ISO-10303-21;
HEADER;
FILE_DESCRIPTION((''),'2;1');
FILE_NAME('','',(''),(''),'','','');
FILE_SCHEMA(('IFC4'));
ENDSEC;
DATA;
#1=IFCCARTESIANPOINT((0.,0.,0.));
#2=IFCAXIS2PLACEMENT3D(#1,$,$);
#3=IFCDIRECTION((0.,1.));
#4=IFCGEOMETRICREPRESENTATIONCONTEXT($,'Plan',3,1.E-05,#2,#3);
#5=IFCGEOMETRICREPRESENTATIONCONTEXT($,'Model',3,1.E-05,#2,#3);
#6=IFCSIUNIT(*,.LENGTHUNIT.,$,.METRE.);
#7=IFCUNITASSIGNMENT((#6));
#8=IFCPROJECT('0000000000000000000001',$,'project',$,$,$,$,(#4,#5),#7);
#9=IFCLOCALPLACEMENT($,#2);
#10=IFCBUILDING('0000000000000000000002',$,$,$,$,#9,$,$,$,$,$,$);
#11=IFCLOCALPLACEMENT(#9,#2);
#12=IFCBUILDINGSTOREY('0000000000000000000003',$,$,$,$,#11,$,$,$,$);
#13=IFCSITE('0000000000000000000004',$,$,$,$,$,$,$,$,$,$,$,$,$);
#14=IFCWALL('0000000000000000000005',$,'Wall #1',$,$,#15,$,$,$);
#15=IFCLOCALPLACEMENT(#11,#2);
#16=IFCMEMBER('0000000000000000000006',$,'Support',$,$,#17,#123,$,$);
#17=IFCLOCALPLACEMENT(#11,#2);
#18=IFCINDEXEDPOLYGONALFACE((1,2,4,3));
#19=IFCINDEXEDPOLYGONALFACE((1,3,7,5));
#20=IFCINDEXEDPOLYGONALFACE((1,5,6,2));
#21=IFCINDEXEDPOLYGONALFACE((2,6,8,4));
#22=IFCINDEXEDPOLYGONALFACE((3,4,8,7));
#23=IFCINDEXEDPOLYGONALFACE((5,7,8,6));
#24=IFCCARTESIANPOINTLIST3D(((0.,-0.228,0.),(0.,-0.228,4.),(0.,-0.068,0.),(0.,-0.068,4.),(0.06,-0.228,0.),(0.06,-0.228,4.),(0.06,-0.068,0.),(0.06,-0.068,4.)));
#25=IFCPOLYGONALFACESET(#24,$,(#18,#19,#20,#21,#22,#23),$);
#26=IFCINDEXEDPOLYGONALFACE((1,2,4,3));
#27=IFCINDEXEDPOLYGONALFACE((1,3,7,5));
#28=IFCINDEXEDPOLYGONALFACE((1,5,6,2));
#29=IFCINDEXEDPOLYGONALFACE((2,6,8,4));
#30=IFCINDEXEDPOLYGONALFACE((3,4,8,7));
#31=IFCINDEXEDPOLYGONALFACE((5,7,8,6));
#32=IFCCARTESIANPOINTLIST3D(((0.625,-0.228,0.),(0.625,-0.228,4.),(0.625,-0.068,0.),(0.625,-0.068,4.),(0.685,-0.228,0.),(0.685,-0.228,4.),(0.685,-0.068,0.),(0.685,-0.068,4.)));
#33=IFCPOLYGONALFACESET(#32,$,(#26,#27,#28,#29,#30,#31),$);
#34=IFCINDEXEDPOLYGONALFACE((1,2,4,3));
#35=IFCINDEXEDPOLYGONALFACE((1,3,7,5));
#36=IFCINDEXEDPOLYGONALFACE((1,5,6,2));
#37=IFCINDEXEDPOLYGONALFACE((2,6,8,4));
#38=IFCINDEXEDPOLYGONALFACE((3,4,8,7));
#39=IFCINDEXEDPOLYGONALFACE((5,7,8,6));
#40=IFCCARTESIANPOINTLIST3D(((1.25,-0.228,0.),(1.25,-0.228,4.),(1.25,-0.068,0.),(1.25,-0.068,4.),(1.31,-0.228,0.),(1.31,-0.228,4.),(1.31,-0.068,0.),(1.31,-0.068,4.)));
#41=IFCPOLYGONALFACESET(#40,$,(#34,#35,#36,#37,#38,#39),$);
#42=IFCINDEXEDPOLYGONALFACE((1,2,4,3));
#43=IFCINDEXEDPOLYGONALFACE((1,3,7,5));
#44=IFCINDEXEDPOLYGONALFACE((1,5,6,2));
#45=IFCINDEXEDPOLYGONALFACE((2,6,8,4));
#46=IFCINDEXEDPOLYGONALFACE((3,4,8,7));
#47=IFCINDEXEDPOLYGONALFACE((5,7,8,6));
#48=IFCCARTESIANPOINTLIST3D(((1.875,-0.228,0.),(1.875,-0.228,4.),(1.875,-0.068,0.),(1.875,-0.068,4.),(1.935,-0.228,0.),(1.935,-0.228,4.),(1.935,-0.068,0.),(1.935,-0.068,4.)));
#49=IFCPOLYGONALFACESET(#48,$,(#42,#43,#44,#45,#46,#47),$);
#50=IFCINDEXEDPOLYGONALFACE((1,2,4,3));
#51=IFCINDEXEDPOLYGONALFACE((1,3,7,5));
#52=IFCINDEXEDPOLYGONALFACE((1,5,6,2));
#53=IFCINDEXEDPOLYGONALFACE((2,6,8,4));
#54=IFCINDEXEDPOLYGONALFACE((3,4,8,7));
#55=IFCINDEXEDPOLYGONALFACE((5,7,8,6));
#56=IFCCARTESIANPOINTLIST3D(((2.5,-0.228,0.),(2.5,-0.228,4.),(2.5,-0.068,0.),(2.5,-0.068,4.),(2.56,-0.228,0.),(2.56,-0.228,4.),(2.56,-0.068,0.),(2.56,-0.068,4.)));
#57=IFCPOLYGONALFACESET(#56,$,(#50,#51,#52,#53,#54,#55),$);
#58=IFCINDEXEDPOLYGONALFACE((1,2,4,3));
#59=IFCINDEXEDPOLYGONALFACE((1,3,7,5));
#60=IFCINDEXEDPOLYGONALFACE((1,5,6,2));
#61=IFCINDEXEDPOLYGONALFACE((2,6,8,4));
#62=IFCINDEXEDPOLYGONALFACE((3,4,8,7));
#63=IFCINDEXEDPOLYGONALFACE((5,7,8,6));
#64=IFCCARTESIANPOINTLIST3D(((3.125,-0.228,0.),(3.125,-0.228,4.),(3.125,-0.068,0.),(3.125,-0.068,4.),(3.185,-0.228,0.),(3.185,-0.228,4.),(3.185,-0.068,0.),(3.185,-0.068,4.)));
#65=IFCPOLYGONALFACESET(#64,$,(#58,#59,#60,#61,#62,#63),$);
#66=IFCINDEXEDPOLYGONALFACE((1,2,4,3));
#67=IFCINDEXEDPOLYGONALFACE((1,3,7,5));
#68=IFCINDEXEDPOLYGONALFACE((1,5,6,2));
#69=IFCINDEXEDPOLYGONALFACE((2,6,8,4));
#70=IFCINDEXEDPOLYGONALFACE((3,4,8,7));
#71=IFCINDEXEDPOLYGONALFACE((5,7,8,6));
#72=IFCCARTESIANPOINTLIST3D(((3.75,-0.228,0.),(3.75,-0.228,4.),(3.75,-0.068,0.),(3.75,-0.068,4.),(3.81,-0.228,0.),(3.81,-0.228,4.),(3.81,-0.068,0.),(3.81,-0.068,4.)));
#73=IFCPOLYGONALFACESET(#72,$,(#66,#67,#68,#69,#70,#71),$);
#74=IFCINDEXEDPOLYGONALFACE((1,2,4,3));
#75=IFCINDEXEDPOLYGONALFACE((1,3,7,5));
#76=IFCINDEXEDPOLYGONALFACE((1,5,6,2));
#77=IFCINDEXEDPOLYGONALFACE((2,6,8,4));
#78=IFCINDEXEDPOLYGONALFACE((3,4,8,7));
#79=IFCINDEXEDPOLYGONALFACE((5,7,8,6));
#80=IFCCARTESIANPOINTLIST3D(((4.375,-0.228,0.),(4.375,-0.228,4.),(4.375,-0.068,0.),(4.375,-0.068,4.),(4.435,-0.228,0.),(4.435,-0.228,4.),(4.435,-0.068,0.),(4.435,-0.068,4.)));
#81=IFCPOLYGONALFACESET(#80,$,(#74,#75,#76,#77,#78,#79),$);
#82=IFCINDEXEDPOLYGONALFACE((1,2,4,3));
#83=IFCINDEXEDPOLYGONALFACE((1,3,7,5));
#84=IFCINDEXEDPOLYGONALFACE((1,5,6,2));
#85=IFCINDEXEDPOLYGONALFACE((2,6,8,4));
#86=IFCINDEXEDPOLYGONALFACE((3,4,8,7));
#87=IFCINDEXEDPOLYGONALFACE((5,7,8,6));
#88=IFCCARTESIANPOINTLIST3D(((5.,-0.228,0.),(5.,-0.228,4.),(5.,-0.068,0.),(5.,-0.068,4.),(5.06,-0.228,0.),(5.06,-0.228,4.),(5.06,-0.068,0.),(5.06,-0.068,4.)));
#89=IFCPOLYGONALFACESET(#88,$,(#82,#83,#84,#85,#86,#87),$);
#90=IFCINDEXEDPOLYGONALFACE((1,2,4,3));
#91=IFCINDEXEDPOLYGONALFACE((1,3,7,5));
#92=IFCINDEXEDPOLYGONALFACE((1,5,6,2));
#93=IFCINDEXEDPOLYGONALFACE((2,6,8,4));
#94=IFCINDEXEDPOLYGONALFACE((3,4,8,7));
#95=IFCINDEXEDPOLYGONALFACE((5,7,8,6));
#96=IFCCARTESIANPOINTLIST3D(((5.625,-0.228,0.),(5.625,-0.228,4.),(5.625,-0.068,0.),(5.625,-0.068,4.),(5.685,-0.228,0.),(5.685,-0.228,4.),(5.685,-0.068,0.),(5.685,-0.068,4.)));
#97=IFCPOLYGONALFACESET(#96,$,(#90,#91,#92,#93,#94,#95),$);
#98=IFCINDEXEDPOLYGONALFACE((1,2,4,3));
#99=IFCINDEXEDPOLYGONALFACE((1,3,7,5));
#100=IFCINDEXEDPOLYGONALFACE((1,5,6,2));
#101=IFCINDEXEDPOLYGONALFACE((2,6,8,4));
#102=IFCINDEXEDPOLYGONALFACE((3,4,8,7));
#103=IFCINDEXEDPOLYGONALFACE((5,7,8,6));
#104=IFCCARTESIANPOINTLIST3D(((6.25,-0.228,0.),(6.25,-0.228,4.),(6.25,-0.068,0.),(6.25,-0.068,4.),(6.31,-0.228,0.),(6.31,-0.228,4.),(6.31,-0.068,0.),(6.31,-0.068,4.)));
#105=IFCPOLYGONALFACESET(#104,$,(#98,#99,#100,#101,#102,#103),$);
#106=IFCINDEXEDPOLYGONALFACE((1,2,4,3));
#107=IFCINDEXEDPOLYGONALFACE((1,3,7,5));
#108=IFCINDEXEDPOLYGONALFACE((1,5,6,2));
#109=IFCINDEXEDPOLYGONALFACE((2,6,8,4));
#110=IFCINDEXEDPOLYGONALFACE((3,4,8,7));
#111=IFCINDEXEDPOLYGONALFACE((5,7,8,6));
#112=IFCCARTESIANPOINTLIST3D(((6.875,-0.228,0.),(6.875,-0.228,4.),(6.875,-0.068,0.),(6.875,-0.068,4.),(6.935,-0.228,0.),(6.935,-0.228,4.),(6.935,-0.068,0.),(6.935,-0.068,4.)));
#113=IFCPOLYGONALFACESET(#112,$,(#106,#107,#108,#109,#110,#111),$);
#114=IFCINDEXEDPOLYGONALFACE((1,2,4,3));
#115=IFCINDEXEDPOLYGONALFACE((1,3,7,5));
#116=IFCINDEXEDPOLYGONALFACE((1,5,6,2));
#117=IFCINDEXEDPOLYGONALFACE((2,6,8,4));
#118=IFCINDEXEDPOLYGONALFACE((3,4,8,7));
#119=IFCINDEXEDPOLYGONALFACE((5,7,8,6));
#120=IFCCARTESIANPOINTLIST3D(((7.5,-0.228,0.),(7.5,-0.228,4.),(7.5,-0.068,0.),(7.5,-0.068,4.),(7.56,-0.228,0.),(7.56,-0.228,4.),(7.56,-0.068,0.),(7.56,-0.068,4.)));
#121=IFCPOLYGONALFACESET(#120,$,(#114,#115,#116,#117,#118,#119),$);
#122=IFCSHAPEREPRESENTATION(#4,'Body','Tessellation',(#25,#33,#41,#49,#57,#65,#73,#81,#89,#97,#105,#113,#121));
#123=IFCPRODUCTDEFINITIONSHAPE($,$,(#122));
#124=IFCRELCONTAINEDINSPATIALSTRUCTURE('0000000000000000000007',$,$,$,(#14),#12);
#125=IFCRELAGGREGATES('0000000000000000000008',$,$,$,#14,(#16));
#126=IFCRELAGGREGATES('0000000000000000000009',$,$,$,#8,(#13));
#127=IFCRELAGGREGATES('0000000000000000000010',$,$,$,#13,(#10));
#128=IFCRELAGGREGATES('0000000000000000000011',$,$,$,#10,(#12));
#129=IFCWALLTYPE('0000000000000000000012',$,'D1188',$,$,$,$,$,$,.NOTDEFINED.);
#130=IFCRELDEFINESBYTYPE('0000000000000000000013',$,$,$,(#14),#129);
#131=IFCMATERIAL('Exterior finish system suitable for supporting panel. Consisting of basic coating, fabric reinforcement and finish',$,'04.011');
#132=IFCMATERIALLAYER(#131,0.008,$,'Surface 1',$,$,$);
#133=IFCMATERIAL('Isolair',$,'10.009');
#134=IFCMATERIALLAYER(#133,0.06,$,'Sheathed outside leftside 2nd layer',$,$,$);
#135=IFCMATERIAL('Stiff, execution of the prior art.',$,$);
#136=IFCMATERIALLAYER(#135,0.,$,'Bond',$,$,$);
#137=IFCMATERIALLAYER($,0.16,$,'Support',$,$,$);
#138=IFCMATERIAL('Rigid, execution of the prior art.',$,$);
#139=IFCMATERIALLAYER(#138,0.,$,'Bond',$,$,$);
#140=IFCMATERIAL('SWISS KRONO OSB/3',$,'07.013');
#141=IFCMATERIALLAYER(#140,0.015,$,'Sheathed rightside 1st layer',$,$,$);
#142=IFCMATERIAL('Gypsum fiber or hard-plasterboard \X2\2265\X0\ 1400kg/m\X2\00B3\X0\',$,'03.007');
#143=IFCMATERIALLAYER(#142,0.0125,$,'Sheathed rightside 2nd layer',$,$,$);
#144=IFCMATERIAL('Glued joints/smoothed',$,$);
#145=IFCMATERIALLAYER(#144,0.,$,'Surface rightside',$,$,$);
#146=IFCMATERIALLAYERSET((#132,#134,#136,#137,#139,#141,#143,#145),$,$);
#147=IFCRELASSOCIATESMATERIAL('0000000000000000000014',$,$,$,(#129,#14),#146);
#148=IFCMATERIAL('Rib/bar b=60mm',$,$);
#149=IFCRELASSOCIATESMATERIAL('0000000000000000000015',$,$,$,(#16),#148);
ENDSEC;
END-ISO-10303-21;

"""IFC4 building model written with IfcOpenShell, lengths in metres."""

from ifc_helpers import new_model, si_unit, direction, frame, frame_2d, origin, place, context, project, spatial, rectangle, extrude, material, layer, layer_set, type_object, element, aggregate, save


model = new_model("IFC4")

# Units and contexts
plan_context = context("Plan", 3, precision=1e-05, world=origin(), true_north=direction((0.0, 1.0)))
model_context = context("Model", 3, precision=1e-05, world=origin(), true_north=direction((0.0, 1.0)))
ifc_project = project(units=[si_unit("LENGTHUNIT", "METRE")], contexts=[plan_context, model_context])

# Site, building, storey
site = spatial("IfcSite", under=ifc_project)
building_placement = place(None, origin())
building = spatial("IfcBuilding", under=site, at=building_placement)
storey_placement = place(building_placement, origin())
storey = spatial("IfcBuildingStorey", under=building, at=storey_placement)

# Wall, member
ifc_material_1 = material(Name="Exterior finish system suitable for supporting panel. Consisting of basic coating, fabric reinforcement and finish", Category="04.011")
ifc_layer_1 = layer(ifc_material_1, 0.008, Name="Surface 1")
ifc_material_2 = material(Name="Isolair", Category="10.009")
ifc_layer_2 = layer(ifc_material_2, 0.06, Name="Sheathed outside leftside 2nd layer")
ifc_material_3 = material(Name="Stiff, execution of the prior art.")
ifc_layer_3 = layer(ifc_material_3, 0.0, Name="Bond")
ifc_layer_4 = layer(None, 0.16, Name="Support")
ifc_material_4 = material(Name="Rigid, execution of the prior art.")
ifc_layer_5 = layer(ifc_material_4, 0.0, Name="Bond")
ifc_material_5 = material(Name="SWISS KRONO OSB/3", Category="07.013")
ifc_layer_6 = layer(ifc_material_5, 0.015, Name="Sheathed rightside 1st layer")
ifc_material_6 = material(Name="Gypsum fiber or hard-plasterboard ≥ 1400kg/m³", Category="03.007")
ifc_layer_7 = layer(ifc_material_6, 0.0125, Name="Sheathed rightside 2nd layer")
ifc_material_7 = material(Name="Glued joints/smoothed")
ifc_layer_8 = layer(ifc_material_7, 0.0, Name="Surface rightside")
ifc_layer_set = layer_set([ifc_layer_1, ifc_layer_2, ifc_layer_3, ifc_layer_4, ifc_layer_5, ifc_layer_6, ifc_layer_7, ifc_layer_8])
wall_type = type_object("IfcWallType", Name="D1188", PredefinedType="NOTDEFINED", material=ifc_layer_set)
wall_placement = place(None, frame((0.0, 0.0, 0.0), z_axis=(0.0, -1.0, 0.0), x_axis=(1.0, 0.0, 0.0)))
wall = element("IfcWall", 1, at=wall_placement, inside=storey, type_object=wall_type, material=ifc_layer_set, Name="Wall #1")
ifc_material_8 = material(Name="Rib/bar b=60mm")
member_1_placement = place(wall_placement, origin())
member_1 = element("IfcMember", 2, at=member_1_placement, material=ifc_material_8, Name="Support", context=plan_context, shape_type="SweptSolid", body=[
    extrude(rectangle(XDim=0.06, YDim=0.16, at=frame_2d((0.03, 0.08), x_axis=(1.0, 0.0))), frame((0.0, 4.0, 0.068), z_axis=(0.0, -1.0, 0.0), x_axis=(1.0, 0.0, 0.0)), (0.0, 0.0, 1.0), 4.0),
    extrude(rectangle(XDim=0.06, YDim=0.16, at=frame_2d((0.03, 0.08), x_axis=(1.0, 0.0))), frame((0.625, 4.0, 0.068), z_axis=(0.0, -1.0, 0.0), x_axis=(1.0, 0.0, 0.0)), (0.0, 0.0, 1.0), 4.0),
    extrude(rectangle(XDim=0.06, YDim=0.16, at=frame_2d((0.03, 0.08), x_axis=(1.0, 0.0))), frame((1.25, 4.0, 0.068), z_axis=(0.0, -1.0, 0.0), x_axis=(1.0, 0.0, 0.0)), (0.0, 0.0, 1.0), 4.0),
    extrude(rectangle(XDim=0.06, YDim=0.16, at=frame_2d((0.03, 0.08), x_axis=(1.0, 0.0))), frame((1.875, 4.0, 0.068), z_axis=(0.0, -1.0, 0.0), x_axis=(1.0, 0.0, 0.0)), (0.0, 0.0, 1.0), 4.0),
    extrude(rectangle(XDim=0.06, YDim=0.16, at=frame_2d((0.03, 0.08), x_axis=(1.0, 0.0))), frame((2.5, 4.0, 0.068), z_axis=(0.0, -1.0, 0.0), x_axis=(1.0, 0.0, 0.0)), (0.0, 0.0, 1.0), 4.0),
    extrude(rectangle(XDim=0.06, YDim=0.16, at=frame_2d((0.03, 0.08), x_axis=(1.0, 0.0))), frame((3.125, 4.0, 0.068), z_axis=(0.0, -1.0, 0.0), x_axis=(1.0, 0.0, 0.0)), (0.0, 0.0, 1.0), 4.0),
    extrude(rectangle(XDim=0.06, YDim=0.16, at=frame_2d((0.03, 0.08), x_axis=(1.0, 0.0))), frame((3.75, 4.0, 0.068), z_axis=(0.0, -1.0, 0.0), x_axis=(1.0, 0.0, 0.0)), (0.0, 0.0, 1.0), 4.0),
    extrude(rectangle(XDim=0.06, YDim=0.16, at=frame_2d((0.03, 0.08), x_axis=(1.0, 0.0))), frame((4.375, 4.0, 0.068), z_axis=(0.0, -1.0, 0.0), x_axis=(1.0, 0.0, 0.0)), (0.0, 0.0, 1.0), 4.0),
    extrude(rectangle(XDim=0.06, YDim=0.16, at=frame_2d((0.03, 0.08), x_axis=(1.0, 0.0))), frame((5.0, 4.0, 0.068), z_axis=(0.0, -1.0, 0.0), x_axis=(1.0, 0.0, 0.0)), (0.0, 0.0, 1.0), 4.0),
    extrude(rectangle(XDim=0.06, YDim=0.16, at=frame_2d((0.03, 0.08), x_axis=(1.0, 0.0))), frame((5.625, 4.0, 0.068), z_axis=(0.0, -1.0, 0.0), x_axis=(1.0, 0.0, 0.0)), (0.0, 0.0, 1.0), 4.0),
    extrude(rectangle(XDim=0.06, YDim=0.16, at=frame_2d((0.03, 0.08), x_axis=(1.0, 0.0))), frame((6.25, 4.0, 0.068), z_axis=(0.0, -1.0, 0.0), x_axis=(1.0, 0.0, 0.0)), (0.0, 0.0, 1.0), 4.0),
    extrude(rectangle(XDim=0.06, YDim=0.16, at=frame_2d((0.03, 0.08), x_axis=(1.0, 0.0))), frame((6.875, 4.0, 0.068), z_axis=(0.0, -1.0, 0.0), x_axis=(1.0, 0.0, 0.0)), (0.0, 0.0, 1.0), 4.0),
    extrude(rectangle(XDim=0.06, YDim=0.16, at=frame_2d((0.03, 0.08), x_axis=(1.0, 0.0))), frame((7.5, 4.0, 0.068), z_axis=(0.0, -1.0, 0.0), x_axis=(1.0, 0.0, 0.0)), (0.0, 0.0, 1.0), 4.0),
])
aggregate(wall, [member_1])

save(model, "model.ifc")
